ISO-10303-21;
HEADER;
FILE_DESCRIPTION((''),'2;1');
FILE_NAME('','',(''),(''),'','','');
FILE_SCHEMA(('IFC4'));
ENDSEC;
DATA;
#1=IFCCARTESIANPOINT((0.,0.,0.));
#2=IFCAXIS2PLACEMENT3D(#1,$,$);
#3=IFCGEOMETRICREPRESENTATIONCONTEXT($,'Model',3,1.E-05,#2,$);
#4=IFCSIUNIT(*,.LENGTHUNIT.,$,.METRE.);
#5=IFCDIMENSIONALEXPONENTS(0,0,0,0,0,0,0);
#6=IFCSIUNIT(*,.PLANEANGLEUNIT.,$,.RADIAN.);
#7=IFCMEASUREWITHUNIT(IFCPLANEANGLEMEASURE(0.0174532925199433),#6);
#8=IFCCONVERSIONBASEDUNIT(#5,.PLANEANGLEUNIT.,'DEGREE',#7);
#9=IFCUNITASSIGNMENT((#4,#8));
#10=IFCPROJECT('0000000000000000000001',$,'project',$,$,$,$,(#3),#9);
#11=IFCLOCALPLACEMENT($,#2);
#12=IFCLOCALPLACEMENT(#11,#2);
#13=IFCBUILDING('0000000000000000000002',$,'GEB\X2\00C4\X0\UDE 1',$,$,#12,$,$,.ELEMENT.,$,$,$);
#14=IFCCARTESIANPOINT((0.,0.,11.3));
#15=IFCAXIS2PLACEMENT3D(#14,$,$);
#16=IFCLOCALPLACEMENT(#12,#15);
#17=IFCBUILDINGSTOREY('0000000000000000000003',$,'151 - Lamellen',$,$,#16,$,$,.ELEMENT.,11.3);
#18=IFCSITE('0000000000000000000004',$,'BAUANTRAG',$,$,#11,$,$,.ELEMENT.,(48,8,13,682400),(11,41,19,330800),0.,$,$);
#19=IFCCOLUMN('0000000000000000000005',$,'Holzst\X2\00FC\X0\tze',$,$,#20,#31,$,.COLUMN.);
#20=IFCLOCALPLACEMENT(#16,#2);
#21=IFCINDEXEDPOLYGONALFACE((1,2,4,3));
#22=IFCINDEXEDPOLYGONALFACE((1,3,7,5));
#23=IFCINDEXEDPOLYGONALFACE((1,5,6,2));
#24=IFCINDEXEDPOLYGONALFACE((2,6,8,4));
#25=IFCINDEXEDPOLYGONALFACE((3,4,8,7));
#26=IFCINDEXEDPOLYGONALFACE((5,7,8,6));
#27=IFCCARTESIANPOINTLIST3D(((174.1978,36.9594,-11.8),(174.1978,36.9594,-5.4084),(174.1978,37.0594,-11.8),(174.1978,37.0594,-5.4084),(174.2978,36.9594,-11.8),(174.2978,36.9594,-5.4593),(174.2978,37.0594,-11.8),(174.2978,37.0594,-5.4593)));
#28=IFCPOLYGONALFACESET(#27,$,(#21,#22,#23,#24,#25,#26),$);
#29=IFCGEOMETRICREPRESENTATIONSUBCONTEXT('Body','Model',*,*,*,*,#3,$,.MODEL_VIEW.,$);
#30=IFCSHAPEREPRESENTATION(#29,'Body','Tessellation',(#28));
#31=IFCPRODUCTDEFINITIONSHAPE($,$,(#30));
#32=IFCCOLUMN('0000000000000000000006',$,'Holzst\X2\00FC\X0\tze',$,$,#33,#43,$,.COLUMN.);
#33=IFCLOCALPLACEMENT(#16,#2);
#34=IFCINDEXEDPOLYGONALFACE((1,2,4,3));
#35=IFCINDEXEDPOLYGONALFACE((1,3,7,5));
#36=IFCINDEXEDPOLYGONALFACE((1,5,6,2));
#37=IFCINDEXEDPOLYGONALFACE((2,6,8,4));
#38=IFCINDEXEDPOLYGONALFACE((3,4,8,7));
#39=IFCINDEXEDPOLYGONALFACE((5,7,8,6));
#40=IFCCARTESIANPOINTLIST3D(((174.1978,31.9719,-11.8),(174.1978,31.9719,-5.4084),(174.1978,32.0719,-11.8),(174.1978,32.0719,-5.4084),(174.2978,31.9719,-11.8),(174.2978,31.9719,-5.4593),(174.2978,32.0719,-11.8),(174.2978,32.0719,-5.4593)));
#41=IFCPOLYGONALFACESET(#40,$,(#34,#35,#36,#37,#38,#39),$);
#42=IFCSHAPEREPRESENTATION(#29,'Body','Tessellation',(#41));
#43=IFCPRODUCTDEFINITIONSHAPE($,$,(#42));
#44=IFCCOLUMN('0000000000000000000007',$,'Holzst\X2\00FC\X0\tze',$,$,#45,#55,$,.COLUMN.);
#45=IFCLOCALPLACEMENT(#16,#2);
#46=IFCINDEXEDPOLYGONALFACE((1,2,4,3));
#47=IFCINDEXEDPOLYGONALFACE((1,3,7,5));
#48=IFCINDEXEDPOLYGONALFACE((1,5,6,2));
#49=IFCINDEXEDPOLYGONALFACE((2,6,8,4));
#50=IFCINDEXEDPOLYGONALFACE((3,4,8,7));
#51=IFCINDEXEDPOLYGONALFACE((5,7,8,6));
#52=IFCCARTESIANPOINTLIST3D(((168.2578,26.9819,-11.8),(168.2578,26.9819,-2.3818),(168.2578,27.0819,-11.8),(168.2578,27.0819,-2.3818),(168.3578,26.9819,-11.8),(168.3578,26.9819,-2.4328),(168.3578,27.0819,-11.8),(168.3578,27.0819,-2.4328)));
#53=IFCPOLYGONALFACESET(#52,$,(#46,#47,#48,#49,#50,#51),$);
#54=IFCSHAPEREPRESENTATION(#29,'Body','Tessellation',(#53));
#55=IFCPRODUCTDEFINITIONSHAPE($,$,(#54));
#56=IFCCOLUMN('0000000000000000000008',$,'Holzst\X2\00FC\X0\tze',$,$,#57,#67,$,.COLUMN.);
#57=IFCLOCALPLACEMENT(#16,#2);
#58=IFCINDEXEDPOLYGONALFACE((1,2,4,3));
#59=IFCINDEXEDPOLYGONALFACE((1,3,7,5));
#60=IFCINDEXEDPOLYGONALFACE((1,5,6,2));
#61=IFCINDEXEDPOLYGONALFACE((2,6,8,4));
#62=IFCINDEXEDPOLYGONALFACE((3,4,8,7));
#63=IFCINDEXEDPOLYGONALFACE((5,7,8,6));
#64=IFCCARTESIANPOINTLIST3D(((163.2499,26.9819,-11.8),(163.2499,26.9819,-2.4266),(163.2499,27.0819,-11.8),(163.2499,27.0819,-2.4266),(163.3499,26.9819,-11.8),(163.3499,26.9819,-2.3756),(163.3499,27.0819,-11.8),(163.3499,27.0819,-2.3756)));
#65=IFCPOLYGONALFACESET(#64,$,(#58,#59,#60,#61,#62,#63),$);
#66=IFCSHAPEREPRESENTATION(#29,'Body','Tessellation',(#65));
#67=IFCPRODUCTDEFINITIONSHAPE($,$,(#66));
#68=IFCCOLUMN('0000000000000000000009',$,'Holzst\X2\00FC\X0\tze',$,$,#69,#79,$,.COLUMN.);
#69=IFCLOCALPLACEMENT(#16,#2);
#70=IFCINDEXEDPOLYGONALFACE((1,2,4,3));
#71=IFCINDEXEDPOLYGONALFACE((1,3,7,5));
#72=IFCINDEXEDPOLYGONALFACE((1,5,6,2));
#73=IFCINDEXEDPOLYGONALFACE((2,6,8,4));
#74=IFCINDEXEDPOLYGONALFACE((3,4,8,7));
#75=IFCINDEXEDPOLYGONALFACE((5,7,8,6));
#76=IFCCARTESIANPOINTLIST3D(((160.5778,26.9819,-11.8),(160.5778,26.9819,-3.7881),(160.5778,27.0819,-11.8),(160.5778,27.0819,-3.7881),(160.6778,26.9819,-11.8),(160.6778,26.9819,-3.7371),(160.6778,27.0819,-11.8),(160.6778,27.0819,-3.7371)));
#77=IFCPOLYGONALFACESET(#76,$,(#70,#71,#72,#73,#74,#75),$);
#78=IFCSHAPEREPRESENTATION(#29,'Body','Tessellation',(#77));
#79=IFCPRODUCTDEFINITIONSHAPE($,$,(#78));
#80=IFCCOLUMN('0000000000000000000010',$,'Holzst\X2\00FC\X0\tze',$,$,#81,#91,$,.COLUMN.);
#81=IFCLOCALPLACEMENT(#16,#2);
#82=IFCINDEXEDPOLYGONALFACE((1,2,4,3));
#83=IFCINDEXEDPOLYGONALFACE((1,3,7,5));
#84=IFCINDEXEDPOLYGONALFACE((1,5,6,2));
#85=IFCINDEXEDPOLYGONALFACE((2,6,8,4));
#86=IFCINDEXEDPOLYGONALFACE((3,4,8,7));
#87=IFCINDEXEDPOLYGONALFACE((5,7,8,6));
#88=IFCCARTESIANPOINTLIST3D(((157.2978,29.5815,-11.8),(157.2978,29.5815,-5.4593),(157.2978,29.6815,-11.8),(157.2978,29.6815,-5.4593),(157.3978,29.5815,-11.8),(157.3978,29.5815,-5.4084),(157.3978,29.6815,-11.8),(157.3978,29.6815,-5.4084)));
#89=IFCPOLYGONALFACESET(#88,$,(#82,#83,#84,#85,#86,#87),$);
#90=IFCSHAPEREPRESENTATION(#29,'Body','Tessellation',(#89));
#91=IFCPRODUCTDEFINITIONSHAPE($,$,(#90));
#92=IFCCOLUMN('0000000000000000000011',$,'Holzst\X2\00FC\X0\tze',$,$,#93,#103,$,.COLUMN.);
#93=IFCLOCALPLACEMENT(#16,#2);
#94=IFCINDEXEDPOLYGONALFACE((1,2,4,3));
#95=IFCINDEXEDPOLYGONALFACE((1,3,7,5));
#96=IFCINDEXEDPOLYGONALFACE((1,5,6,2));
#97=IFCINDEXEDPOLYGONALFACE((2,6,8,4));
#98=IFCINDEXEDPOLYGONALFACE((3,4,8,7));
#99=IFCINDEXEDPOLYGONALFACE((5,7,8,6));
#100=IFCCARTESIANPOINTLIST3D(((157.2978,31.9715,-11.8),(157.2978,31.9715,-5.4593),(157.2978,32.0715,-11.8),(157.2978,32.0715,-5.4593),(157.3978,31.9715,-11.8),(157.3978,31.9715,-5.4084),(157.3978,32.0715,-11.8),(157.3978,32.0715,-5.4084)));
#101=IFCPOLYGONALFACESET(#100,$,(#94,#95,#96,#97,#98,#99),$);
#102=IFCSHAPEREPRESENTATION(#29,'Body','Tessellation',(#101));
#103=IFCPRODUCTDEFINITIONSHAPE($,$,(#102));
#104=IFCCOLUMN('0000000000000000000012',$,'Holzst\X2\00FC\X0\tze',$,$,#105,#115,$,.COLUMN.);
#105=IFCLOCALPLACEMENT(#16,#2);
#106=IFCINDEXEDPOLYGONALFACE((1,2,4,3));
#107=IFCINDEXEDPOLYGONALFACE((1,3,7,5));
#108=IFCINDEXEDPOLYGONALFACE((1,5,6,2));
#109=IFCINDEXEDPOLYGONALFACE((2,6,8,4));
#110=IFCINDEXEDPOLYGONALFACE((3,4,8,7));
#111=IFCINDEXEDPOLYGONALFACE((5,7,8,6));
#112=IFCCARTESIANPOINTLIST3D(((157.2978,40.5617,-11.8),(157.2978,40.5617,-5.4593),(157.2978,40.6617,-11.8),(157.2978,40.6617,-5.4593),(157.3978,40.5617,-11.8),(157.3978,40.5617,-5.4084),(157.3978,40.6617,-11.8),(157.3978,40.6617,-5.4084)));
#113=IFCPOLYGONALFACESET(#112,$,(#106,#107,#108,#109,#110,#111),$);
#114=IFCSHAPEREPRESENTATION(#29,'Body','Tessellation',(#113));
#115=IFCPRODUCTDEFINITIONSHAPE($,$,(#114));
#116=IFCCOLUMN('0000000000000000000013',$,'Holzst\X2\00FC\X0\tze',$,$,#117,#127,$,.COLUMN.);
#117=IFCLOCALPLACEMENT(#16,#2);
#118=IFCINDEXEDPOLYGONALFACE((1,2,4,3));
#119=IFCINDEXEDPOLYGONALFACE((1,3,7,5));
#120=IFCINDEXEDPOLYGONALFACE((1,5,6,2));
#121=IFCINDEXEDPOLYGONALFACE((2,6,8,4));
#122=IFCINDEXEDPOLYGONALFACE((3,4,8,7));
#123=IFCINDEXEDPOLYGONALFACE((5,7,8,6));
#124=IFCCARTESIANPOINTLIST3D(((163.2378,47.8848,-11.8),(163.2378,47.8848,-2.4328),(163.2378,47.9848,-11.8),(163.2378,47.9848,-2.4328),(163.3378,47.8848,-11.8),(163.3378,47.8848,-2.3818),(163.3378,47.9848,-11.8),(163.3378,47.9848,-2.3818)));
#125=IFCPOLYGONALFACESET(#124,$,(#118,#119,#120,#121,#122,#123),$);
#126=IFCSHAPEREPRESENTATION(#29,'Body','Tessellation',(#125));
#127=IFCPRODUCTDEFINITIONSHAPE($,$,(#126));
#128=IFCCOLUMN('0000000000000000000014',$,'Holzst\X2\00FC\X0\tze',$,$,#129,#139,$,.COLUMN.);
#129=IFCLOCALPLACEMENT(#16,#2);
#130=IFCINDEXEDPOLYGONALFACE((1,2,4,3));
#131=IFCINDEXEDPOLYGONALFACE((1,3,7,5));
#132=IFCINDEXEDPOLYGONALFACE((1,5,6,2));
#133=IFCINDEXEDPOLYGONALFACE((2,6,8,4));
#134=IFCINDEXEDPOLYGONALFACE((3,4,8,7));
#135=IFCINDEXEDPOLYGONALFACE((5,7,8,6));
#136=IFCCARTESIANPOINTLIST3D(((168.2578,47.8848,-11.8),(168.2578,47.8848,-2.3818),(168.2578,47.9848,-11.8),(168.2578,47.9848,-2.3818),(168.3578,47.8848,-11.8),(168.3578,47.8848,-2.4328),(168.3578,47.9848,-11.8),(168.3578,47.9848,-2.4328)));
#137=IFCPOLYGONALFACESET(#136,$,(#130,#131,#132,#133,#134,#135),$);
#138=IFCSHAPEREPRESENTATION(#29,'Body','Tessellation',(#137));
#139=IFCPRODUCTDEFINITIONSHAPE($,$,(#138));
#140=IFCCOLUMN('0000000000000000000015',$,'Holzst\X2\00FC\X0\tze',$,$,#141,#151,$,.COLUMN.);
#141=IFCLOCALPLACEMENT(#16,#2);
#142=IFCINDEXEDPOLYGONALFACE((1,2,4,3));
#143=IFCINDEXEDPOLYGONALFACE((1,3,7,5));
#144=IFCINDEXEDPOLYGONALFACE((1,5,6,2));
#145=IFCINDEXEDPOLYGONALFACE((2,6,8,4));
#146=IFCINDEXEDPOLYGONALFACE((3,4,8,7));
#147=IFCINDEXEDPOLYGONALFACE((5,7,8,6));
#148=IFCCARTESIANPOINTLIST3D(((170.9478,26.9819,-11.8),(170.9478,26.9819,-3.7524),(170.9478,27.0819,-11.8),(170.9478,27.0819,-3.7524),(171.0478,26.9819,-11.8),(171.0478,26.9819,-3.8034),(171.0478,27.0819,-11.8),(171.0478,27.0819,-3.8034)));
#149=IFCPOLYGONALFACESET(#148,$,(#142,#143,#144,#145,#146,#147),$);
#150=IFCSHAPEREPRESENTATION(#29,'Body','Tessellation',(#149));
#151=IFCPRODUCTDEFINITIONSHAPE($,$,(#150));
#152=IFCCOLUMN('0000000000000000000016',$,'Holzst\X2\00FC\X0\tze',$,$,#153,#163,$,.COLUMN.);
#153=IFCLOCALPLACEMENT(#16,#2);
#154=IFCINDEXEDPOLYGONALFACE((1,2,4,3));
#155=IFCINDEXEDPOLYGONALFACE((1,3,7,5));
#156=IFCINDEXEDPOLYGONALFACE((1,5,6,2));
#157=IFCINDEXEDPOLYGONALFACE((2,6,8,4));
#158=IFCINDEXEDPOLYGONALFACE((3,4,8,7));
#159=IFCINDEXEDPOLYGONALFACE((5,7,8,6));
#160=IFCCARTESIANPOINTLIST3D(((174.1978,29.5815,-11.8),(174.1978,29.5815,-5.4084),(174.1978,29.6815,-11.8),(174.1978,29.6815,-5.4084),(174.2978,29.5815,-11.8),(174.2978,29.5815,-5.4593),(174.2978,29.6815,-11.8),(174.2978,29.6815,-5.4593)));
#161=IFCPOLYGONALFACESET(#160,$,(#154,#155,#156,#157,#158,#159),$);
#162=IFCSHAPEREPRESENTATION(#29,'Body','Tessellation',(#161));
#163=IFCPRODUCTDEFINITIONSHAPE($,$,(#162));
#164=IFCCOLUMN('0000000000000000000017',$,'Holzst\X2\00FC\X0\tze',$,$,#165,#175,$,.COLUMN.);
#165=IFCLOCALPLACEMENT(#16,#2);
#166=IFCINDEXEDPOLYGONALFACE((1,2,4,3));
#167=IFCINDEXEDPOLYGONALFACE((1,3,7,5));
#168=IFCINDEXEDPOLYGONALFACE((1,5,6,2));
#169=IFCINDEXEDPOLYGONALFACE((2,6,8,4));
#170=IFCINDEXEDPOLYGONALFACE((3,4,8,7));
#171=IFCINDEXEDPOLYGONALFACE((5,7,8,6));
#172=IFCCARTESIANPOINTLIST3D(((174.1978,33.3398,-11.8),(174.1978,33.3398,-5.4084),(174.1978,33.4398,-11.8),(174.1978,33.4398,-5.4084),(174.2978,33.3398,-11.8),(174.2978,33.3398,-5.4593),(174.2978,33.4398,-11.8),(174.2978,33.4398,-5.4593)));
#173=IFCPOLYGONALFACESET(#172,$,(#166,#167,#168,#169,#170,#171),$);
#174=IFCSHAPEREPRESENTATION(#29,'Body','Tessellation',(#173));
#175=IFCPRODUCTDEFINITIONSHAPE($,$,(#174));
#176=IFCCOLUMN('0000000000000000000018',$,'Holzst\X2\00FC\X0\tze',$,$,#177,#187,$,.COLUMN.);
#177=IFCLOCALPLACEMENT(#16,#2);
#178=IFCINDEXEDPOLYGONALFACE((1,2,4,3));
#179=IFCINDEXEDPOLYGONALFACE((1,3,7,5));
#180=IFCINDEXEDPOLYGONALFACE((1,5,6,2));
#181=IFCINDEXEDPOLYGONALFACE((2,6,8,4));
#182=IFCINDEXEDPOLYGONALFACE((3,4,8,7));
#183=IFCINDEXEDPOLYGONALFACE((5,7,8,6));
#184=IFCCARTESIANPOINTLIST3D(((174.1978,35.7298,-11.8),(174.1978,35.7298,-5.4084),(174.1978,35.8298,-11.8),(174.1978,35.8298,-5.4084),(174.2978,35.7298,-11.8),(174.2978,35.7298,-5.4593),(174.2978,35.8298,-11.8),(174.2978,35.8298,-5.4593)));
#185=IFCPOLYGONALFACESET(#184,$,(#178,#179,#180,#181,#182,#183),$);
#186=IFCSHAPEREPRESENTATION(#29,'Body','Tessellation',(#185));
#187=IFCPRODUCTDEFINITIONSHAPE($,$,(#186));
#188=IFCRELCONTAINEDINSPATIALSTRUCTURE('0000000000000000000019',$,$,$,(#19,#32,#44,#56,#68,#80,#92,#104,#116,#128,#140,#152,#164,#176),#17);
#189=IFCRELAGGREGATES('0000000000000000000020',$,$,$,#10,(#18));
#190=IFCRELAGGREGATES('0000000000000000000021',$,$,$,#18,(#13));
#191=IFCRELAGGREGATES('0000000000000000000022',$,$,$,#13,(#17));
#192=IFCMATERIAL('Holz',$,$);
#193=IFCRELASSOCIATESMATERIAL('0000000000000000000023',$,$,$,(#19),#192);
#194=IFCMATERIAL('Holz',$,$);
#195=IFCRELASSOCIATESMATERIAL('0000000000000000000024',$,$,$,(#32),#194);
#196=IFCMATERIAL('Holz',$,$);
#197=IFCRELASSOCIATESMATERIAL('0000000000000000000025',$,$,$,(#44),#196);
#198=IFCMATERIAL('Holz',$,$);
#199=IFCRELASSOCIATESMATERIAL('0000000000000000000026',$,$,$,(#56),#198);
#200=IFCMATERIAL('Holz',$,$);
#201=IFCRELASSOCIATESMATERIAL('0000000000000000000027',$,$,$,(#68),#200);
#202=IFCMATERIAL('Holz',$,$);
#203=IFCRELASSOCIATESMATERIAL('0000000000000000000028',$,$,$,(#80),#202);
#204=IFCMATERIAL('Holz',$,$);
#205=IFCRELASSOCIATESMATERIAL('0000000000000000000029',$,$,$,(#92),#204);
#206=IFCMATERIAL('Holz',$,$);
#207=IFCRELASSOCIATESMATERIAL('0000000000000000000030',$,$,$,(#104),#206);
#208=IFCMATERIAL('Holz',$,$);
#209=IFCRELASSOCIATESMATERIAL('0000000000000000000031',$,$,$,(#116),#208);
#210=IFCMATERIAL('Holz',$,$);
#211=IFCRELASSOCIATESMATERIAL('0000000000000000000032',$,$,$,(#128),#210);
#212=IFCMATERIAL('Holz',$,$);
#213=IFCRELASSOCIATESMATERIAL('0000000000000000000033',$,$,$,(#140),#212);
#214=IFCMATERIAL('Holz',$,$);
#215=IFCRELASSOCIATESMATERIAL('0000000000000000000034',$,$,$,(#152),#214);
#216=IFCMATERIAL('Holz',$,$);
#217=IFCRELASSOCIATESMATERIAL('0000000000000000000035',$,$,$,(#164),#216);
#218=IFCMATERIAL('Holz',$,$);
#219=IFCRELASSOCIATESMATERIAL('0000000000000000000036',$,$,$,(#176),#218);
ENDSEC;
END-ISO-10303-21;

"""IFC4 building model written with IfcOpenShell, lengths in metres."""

from ifc_helpers import new_model, entity, si_unit, converted_unit, frame, frame_2d, origin, origin_with_axes, place, context, subcontext, project, spatial, rectangle, extrude, clip, halfspace, material, element, save


model = new_model("IFC4")

# Units and contexts
model_context = context("Model", 3, precision=1e-05, world=origin())
body_context = subcontext(model_context, "Body", "Model", "MODEL_VIEW")
ifc_project = project(units=[si_unit("LENGTHUNIT", "METRE"), converted_unit("PLANEANGLEUNIT", "DEGREE", entity("IfcPlaneAngleMeasure", 0.0174532925199433), si_unit("PLANEANGLEUNIT", "RADIAN"), dimensions=[0, 0, 0, 0, 0, 0, 0])], contexts=[model_context])

# Site, building, storey
site_placement = place(None, origin())
site = spatial("IfcSite", under=ifc_project, at=site_placement, Name="BAUANTRAG", CompositionType="ELEMENT", RefLatitude=(48, 8, 13, 682400), RefLongitude=(11, 41, 19, 330800), RefElevation=0.0)
building_placement = place(site_placement, origin())
building = spatial("IfcBuilding", under=site, at=building_placement, Name="GEBÄUDE 1", CompositionType="ELEMENT")
storey_placement = place(building_placement, frame((0.0, 0.0, 11.3)))
storey = spatial("IfcBuildingStorey", under=building, at=storey_placement, Name="151 - Lamellen", CompositionType="ELEMENT", Elevation=11.3)

# Columns
ifc_material_1 = material(Name="Holz")
column_1_placement = place(storey_placement, frame((174.2978, 36.9594, -11.8)))
element("IfcColumn", 1, at=column_1_placement, inside=storey, material=ifc_material_1, Name="Holzstütze", PredefinedType="COLUMN", context=body_context, shape_type="Clipping", body=[
    clip(extrude(rectangle(XDim=0.1, YDim=0.1, at=frame_2d((-0.05, 0.05), x_axis=(0.0, 1.0))), origin_with_axes(), (0.0, 0.0, 1.0), 6.3916), halfspace(frame((-0.05, 0.05, 6.3661), z_axis=(-0.45399, 0.0, -0.891007), x_axis=(0.891007, 0.0, -0.45399)), True)),
])
ifc_material_2 = material(Name="Holz")
column_2_placement = place(storey_placement, frame((174.2978, 31.9719, -11.8)))
element("IfcColumn", 2, at=column_2_placement, inside=storey, material=ifc_material_2, Name="Holzstütze", PredefinedType="COLUMN", context=body_context, shape_type="Clipping", body=[
    clip(extrude(rectangle(XDim=0.1, YDim=0.1, at=frame_2d((-0.05, 0.05), x_axis=(0.0, 1.0))), origin_with_axes(), (0.0, 0.0, 1.0), 6.3916), halfspace(frame((-0.05, 0.05, 6.3661), z_axis=(-0.45399, 0.0, -0.891007), x_axis=(0.891007, 0.0, -0.45399)), True)),
])
ifc_material_3 = material(Name="Holz")
column_3_placement = place(storey_placement, frame((168.3578, 26.9819, -11.8)))
element("IfcColumn", 3, at=column_3_placement, inside=storey, material=ifc_material_3, Name="Holzstütze", PredefinedType="COLUMN", context=body_context, shape_type="Clipping", body=[
    clip(extrude(rectangle(XDim=0.1, YDim=0.1, at=frame_2d((-0.05, 0.05), x_axis=(0.0, 1.0))), origin_with_axes(), (0.0, 0.0, 1.0), 9.4182), halfspace(frame((-0.05, 0.05, 9.3927), z_axis=(-0.45399, 0.0, -0.891007), x_axis=(0.0, -1.0, 0.0)), True)),
])
ifc_material_4 = material(Name="Holz")
column_4_placement = place(storey_placement, frame((163.3499, 26.9819, -11.8)))
element("IfcColumn", 4, at=column_4_placement, inside=storey, material=ifc_material_4, Name="Holzstütze", PredefinedType="COLUMN", context=body_context, shape_type="Clipping", body=[
    clip(extrude(rectangle(XDim=0.1, YDim=0.1, at=frame_2d((-0.05, 0.05), x_axis=(0.0, 1.0))), origin_with_axes(), (0.0, 0.0, 1.0), 9.4244), halfspace(frame((-0.05, 0.05, 9.3989), z_axis=(0.45399, 0.0, -0.891007), x_axis=(0.0, -1.0, 0.0)), True)),
])
ifc_material_5 = material(Name="Holz")
column_5_placement = place(storey_placement, frame((160.6778, 26.9819, -11.8)))
element("IfcColumn", 5, at=column_5_placement, inside=storey, material=ifc_material_5, Name="Holzstütze", PredefinedType="COLUMN", context=body_context, shape_type="Clipping", body=[
    clip(extrude(rectangle(XDim=0.1, YDim=0.1, at=frame_2d((-0.05, 0.05), x_axis=(0.0, 1.0))), origin_with_axes(), (0.0, 0.0, 1.0), 8.0629), halfspace(frame((-0.05, 0.05, 8.0374), z_axis=(0.45399, 0.0, -0.891007), x_axis=(0.0, -1.0, 0.0)), True)),
])
ifc_material_6 = material(Name="Holz")
column_6_placement = place(storey_placement, frame((157.3978, 29.5815, -11.8)))
element("IfcColumn", 6, at=column_6_placement, inside=storey, material=ifc_material_6, Name="Holzstütze", PredefinedType="COLUMN", context=body_context, shape_type="Clipping", body=[
    clip(extrude(rectangle(XDim=0.1, YDim=0.1, at=frame_2d((-0.05, 0.05), x_axis=(0.0, 1.0))), origin_with_axes(), (0.0, 0.0, 1.0), 6.3916), halfspace(frame((-0.05, 0.05, 6.3661), z_axis=(0.45399, 0.0, -0.891007), x_axis=(-0.891007, 0.0, -0.45399)), True)),
])
ifc_material_7 = material(Name="Holz")
column_7_placement = place(storey_placement, frame((157.3978, 31.9715, -11.8)))
element("IfcColumn", 7, at=column_7_placement, inside=storey, material=ifc_material_7, Name="Holzstütze", PredefinedType="COLUMN", context=body_context, shape_type="Clipping", body=[
    clip(extrude(rectangle(XDim=0.1, YDim=0.1, at=frame_2d((-0.05, 0.05), x_axis=(0.0, 1.0))), origin_with_axes(), (0.0, 0.0, 1.0), 6.3916), halfspace(frame((-0.05, 0.05, 6.3661), z_axis=(0.45399, 0.0, -0.891007), x_axis=(-0.891007, 0.0, -0.45399)), True)),
])
ifc_material_8 = material(Name="Holz")
column_8_placement = place(storey_placement, frame((157.3978, 40.5617, -11.8)))
element("IfcColumn", 8, at=column_8_placement, inside=storey, material=ifc_material_8, Name="Holzstütze", PredefinedType="COLUMN", context=body_context, shape_type="Clipping", body=[
    clip(extrude(rectangle(XDim=0.1, YDim=0.1, at=frame_2d((-0.05, 0.05), x_axis=(0.0, 1.0))), origin_with_axes(), (0.0, 0.0, 1.0), 6.3916), halfspace(frame((-0.05, 0.05, 6.3661), z_axis=(0.45399, 0.0, -0.891007), x_axis=(-0.891007, 0.0, -0.45399)), True)),
])
ifc_material_9 = material(Name="Holz")
column_9_placement = place(storey_placement, frame((163.3378, 47.8848, -11.8)))
element("IfcColumn", 9, at=column_9_placement, inside=storey, material=ifc_material_9, Name="Holzstütze", PredefinedType="COLUMN", context=body_context, shape_type="Clipping", body=[
    clip(extrude(rectangle(XDim=0.1, YDim=0.1, at=frame_2d((-0.05, 0.05), x_axis=(0.0, 1.0))), origin_with_axes(), (0.0, 0.0, 1.0), 9.4182), halfspace(frame((-0.05, 0.05, 9.3927), z_axis=(0.45399, 0.0, -0.891007), x_axis=(0.0, 1.0, 0.0)), True)),
])
ifc_material_10 = material(Name="Holz")
column_10_placement = place(storey_placement, frame((168.3578, 47.8848, -11.8)))
element("IfcColumn", 10, at=column_10_placement, inside=storey, material=ifc_material_10, Name="Holzstütze", PredefinedType="COLUMN", context=body_context, shape_type="Clipping", body=[
    clip(extrude(rectangle(XDim=0.1, YDim=0.1, at=frame_2d((-0.05, 0.05), x_axis=(0.0, 1.0))), origin_with_axes(), (0.0, 0.0, 1.0), 9.4182), halfspace(frame((-0.05, 0.05, 9.3927), z_axis=(-0.45399, 0.0, -0.891007), x_axis=(0.0, 1.0, 0.0)), True)),
])
ifc_material_11 = material(Name="Holz")
column_11_placement = place(storey_placement, frame((171.0478, 26.9819, -11.8)))
element("IfcColumn", 11, at=column_11_placement, inside=storey, material=ifc_material_11, Name="Holzstütze", PredefinedType="COLUMN", context=body_context, shape_type="Clipping", body=[
    clip(extrude(rectangle(XDim=0.1, YDim=0.1, at=frame_2d((-0.05, 0.05), x_axis=(0.0, 1.0))), origin_with_axes(), (0.0, 0.0, 1.0), 8.0476), halfspace(frame((-0.05, 0.05, 8.0221), z_axis=(-0.45399, 0.0, -0.891007), x_axis=(0.0, -1.0, 0.0)), True)),
])
ifc_material_12 = material(Name="Holz")
column_12_placement = place(storey_placement, frame((174.2978, 29.5815, -11.8)))
element("IfcColumn", 12, at=column_12_placement, inside=storey, material=ifc_material_12, Name="Holzstütze", PredefinedType="COLUMN", context=body_context, shape_type="Clipping", body=[
    clip(extrude(rectangle(XDim=0.1, YDim=0.1, at=frame_2d((-0.05, 0.05), x_axis=(0.0, 1.0))), origin_with_axes(), (0.0, 0.0, 1.0), 6.3916), halfspace(frame((-0.05, 0.05, 6.3661), z_axis=(-0.45399, 0.0, -0.891007), x_axis=(0.891007, 0.0, -0.45399)), True)),
])
ifc_material_13 = material(Name="Holz")
column_13_placement = place(storey_placement, frame((174.2978, 33.3398, -11.8)))
element("IfcColumn", 13, at=column_13_placement, inside=storey, material=ifc_material_13, Name="Holzstütze", PredefinedType="COLUMN", context=body_context, shape_type="Clipping", body=[
    clip(extrude(rectangle(XDim=0.1, YDim=0.1, at=frame_2d((-0.05, 0.05), x_axis=(0.0, 1.0))), origin_with_axes(), (0.0, 0.0, 1.0), 6.3916), halfspace(frame((-0.05, 0.05, 6.3661), z_axis=(-0.45399, 0.0, -0.891007), x_axis=(0.891007, 0.0, -0.45399)), True)),
])
ifc_material_14 = material(Name="Holz")
column_14_placement = place(storey_placement, frame((174.2978, 35.7298, -11.8)))
element("IfcColumn", 14, at=column_14_placement, inside=storey, material=ifc_material_14, Name="Holzstütze", PredefinedType="COLUMN", context=body_context, shape_type="Clipping", body=[
    clip(extrude(rectangle(XDim=0.1, YDim=0.1, at=frame_2d((-0.05, 0.05), x_axis=(0.0, 1.0))), origin_with_axes(), (0.0, 0.0, 1.0), 6.3916), halfspace(frame((-0.05, 0.05, 6.3661), z_axis=(-0.45399, 0.0, -0.891007), x_axis=(0.891007, 0.0, -0.45399)), True)),
])

save(model, "model.ifc")
